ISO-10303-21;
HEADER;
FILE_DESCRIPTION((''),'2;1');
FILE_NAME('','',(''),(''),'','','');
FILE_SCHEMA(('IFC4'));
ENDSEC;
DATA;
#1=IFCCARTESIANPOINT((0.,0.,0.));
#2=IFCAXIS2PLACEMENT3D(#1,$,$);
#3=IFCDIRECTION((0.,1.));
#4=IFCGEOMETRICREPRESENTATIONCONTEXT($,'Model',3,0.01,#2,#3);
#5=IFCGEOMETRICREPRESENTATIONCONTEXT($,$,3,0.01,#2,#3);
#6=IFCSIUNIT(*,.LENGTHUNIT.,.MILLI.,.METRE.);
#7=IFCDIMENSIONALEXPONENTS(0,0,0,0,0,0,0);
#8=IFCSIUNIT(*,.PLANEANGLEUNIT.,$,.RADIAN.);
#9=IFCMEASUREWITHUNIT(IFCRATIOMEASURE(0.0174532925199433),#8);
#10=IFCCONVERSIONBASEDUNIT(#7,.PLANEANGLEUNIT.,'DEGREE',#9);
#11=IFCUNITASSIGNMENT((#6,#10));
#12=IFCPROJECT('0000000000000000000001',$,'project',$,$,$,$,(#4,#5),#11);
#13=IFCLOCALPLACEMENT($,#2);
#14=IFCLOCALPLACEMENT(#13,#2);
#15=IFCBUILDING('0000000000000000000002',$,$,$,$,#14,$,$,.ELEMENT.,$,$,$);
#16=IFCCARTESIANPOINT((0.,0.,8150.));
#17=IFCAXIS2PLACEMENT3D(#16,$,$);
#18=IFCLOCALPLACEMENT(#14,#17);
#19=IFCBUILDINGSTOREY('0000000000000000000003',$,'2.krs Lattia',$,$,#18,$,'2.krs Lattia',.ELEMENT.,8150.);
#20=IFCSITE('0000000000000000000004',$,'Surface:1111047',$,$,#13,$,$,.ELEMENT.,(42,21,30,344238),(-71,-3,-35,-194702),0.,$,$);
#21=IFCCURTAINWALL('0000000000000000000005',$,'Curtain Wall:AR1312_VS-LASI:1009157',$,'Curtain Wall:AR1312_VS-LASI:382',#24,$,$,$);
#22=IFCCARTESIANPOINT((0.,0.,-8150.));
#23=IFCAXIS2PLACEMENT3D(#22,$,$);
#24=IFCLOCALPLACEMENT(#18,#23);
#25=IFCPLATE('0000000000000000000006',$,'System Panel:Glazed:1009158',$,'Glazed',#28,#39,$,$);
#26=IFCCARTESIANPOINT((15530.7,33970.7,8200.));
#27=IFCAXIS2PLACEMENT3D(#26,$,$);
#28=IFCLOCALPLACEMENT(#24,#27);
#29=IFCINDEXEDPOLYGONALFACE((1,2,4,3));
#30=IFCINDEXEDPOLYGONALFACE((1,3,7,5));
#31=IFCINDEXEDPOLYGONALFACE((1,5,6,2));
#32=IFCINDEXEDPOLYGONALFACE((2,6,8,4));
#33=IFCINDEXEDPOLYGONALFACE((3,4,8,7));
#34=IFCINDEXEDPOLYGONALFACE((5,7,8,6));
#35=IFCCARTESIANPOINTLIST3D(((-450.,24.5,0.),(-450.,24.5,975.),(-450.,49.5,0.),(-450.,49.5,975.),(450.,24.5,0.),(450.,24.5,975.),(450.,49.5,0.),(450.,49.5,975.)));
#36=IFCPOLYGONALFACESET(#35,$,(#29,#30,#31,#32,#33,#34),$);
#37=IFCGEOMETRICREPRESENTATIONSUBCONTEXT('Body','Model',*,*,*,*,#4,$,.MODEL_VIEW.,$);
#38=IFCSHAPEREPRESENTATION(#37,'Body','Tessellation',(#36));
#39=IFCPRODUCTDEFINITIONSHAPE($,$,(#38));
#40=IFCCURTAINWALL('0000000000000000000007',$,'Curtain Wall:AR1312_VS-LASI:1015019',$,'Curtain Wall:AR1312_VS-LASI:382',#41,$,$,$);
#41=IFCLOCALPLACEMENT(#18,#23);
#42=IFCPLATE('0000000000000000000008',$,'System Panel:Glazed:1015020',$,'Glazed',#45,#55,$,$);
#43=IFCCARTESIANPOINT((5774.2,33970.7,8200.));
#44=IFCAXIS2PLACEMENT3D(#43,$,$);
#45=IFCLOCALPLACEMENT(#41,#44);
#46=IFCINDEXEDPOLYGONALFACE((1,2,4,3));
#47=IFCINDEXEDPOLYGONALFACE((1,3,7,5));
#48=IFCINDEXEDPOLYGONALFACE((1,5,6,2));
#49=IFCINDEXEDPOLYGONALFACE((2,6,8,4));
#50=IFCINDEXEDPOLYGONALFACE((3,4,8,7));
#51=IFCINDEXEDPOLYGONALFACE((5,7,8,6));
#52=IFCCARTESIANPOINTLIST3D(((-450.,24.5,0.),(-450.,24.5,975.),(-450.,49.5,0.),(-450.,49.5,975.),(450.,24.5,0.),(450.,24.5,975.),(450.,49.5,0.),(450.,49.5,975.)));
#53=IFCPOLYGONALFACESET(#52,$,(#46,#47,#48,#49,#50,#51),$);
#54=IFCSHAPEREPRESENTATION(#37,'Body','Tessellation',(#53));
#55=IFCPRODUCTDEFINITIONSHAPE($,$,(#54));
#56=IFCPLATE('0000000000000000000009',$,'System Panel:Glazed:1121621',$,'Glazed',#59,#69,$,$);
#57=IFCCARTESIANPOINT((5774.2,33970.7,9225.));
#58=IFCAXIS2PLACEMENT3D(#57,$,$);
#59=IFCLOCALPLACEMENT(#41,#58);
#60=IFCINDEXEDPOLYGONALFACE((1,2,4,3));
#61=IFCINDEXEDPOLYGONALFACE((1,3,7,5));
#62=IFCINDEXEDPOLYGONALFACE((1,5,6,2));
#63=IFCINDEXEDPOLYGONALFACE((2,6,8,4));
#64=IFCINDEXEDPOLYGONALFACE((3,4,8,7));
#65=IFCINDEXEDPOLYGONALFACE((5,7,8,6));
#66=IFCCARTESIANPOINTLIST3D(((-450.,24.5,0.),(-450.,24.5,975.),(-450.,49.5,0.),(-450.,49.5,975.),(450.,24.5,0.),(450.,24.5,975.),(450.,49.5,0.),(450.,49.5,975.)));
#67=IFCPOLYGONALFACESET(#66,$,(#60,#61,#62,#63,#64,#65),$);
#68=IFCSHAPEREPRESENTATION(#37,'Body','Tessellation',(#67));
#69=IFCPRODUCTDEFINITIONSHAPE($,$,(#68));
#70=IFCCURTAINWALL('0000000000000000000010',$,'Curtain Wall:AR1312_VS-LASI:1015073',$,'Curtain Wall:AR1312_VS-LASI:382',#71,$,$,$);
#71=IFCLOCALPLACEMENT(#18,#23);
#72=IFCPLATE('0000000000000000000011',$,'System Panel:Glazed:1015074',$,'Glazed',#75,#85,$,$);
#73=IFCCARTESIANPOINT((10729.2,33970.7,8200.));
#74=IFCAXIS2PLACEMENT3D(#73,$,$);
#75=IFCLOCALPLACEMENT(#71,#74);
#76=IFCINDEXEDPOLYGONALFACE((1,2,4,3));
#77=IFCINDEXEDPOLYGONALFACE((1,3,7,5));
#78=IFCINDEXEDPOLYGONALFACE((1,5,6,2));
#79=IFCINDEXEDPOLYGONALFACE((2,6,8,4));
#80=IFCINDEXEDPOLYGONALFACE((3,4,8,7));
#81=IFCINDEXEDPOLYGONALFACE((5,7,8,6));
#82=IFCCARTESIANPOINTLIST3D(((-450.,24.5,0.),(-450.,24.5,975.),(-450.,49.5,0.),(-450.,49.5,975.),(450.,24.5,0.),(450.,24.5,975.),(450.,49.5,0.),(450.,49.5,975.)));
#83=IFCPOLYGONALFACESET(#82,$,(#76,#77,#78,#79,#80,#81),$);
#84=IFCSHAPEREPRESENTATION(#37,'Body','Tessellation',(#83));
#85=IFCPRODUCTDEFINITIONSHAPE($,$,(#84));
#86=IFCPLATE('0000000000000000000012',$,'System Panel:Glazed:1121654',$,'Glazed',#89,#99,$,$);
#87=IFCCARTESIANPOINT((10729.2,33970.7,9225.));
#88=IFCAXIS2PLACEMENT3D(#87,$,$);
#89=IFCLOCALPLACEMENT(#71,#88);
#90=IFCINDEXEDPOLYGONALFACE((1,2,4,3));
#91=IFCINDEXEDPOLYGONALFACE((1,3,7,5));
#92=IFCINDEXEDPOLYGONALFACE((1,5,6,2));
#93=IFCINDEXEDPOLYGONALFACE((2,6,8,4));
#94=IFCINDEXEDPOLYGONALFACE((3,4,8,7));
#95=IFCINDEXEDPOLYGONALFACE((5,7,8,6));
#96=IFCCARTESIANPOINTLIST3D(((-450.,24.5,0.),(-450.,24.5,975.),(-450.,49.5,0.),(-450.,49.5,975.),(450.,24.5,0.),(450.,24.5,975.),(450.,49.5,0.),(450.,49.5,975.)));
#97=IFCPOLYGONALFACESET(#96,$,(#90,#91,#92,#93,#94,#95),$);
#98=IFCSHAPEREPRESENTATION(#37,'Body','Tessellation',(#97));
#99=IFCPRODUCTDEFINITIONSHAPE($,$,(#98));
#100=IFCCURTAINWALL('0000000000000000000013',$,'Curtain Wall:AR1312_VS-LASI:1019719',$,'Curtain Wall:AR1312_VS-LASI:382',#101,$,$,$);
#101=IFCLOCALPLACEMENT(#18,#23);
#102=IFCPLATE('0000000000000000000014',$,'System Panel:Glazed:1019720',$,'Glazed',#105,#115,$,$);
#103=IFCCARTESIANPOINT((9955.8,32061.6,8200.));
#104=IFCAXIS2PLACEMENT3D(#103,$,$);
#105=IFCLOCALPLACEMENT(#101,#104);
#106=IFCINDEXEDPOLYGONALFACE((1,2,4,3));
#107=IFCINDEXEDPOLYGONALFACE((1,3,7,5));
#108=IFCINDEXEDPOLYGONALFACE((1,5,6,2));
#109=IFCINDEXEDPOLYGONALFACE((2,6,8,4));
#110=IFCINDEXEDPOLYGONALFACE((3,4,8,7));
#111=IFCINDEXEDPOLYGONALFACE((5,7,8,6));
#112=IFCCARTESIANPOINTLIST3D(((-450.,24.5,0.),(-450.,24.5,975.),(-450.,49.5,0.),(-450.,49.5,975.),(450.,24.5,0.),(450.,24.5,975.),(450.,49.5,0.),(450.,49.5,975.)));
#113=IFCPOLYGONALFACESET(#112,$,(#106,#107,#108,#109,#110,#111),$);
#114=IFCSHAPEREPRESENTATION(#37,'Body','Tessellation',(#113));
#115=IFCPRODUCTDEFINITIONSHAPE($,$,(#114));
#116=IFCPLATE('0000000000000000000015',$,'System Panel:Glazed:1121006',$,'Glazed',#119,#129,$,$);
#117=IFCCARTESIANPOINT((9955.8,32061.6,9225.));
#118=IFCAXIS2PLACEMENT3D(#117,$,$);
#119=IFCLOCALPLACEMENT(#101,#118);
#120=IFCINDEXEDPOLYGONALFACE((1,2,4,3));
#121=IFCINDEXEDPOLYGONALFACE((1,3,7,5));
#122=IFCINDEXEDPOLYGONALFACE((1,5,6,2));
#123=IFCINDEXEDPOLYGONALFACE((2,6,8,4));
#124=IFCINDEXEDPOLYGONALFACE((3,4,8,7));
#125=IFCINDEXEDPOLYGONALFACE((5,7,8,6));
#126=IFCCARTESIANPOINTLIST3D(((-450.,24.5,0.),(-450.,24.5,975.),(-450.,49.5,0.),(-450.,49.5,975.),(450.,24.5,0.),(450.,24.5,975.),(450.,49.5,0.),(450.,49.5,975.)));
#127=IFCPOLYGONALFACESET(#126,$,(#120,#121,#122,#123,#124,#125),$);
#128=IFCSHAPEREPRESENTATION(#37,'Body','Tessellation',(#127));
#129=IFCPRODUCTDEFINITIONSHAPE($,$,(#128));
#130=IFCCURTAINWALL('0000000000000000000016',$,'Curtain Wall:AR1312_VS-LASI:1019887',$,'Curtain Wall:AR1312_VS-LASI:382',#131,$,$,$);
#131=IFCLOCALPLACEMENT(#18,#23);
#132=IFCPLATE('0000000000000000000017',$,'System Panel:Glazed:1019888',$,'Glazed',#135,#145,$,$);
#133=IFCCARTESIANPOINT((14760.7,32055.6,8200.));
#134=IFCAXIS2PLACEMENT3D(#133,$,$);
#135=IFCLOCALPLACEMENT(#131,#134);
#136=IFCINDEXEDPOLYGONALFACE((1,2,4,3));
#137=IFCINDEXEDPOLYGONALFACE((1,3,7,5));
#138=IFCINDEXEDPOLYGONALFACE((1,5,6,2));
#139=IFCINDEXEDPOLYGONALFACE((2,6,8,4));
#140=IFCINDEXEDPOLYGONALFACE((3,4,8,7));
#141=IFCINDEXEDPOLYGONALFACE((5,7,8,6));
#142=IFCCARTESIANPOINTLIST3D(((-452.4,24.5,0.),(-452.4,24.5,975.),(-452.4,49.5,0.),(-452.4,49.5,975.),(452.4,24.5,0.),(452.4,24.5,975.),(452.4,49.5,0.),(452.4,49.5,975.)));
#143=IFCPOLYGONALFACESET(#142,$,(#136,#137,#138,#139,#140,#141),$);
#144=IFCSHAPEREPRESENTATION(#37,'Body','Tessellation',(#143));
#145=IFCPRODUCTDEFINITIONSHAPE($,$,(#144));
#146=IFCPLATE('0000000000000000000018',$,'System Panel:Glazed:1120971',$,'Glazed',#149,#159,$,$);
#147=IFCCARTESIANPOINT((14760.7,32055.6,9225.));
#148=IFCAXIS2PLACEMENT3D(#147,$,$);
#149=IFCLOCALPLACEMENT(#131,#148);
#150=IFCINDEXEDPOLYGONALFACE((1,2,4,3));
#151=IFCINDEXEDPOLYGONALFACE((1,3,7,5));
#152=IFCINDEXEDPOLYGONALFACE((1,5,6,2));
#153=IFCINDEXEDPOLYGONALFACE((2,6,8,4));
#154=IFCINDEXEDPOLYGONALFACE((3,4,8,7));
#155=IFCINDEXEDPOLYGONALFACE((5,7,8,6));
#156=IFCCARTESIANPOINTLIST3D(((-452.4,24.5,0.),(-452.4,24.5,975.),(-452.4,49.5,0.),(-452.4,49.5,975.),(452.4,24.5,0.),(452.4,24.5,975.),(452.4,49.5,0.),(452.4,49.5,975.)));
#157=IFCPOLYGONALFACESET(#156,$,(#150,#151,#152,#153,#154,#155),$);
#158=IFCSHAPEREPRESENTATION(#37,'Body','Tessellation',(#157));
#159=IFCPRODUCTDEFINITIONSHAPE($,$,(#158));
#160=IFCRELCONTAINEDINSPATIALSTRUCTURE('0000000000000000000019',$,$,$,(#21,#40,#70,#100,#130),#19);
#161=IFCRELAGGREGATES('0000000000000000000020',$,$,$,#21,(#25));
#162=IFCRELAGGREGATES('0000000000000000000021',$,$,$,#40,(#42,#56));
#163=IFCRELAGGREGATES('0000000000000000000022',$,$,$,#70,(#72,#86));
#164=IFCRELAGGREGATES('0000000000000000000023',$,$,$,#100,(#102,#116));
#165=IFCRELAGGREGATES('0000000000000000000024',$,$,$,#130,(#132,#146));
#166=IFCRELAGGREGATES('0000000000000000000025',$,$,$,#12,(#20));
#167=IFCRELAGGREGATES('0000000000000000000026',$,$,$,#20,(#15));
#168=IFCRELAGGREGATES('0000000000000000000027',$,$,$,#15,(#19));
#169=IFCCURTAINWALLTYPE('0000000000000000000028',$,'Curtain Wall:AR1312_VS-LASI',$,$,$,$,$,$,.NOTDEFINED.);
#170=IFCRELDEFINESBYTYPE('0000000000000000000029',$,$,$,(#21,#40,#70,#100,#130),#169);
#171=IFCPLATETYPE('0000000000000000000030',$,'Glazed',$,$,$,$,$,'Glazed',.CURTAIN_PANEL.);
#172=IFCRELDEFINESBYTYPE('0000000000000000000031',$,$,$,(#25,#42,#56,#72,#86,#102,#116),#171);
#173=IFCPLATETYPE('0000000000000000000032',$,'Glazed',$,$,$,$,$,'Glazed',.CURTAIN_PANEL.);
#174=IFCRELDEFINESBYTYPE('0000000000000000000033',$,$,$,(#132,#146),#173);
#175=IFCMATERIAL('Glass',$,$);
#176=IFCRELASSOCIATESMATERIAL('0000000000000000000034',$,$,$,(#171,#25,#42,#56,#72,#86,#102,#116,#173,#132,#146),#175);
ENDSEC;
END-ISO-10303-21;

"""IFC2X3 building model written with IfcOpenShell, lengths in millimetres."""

from ifc_helpers import new_model, entity, si_unit, converted_unit, direction, frame, origin, origin_2d_with_axis, place, context, subcontext, project, spatial, rectangle, extrude, source, transform, mapped, material, type_object, type_shapes, element, aggregate, save


model = new_model("IFC2X3")

# Units and contexts
model_context = context("Model", 3, precision=0.01, world=origin(), true_north=direction((0.0, 1.0)))
context_of_model = context(None, 3, precision=0.01, world=origin(), true_north=direction((0.0, 1.0)))
body_context = subcontext(model_context, "Body", "Model", "MODEL_VIEW")
ifc_project = project(units=[si_unit("LENGTHUNIT", "METRE", prefix="MILLI"), converted_unit("PLANEANGLEUNIT", "DEGREE", entity("IfcRatioMeasure", 0.0174532925199433), si_unit("PLANEANGLEUNIT", "RADIAN"), dimensions=[0, 0, 0, 0, 0, 0, 0])], contexts=[model_context, context_of_model])

# Site, building, storey
site_placement = place(None, origin())
site = spatial("IfcSite", under=ifc_project, at=site_placement, Name="Surface:1111047", CompositionType="ELEMENT", RefLatitude=(42, 21, 30, 344238), RefLongitude=(-71, -3, -35, -194702), RefElevation=0.0)
building_placement = place(site_placement, origin())
building = spatial("IfcBuilding", under=site, at=building_placement, CompositionType="ELEMENT")
storey_placement = place(building_placement, frame((0.0, 0.0, 8150.0)))
storey = spatial("IfcBuildingStorey", under=building, at=storey_placement, Name="2.krs Lattia", LongName="2.krs Lattia", CompositionType="ELEMENT", Elevation=8150.0)

# Curtain wall, plate
curtain_wall_type = type_object("IfcCurtainWallType", Name="Curtain Wall:AR1312_VS-LASI", PredefinedType="NOTDEFINED")
curtain_wall_1_placement = place(storey_placement, frame((0.0, 0.0, -8150.0)))
curtain_wall_1 = element("IfcCurtainWall", 1, at=curtain_wall_1_placement, inside=storey, type_object=curtain_wall_type, Name="Curtain Wall:AR1312_VS-LASI:1009157", ObjectType="Curtain Wall:AR1312_VS-LASI:382")
ifc_material_1 = material(Name="Glass")
plate_type_1 = type_object("IfcPlateType", Name="Glazed", ElementType="Glazed", PredefinedType="CURTAIN_PANEL", material=ifc_material_1)
shared_shape_1 = source(origin(), body_context, "Body", "SweptSolid", [
    extrude(rectangle(XDim=25.0, YDim=900.0, at=origin_2d_with_axis()), frame((0.0, 37.0, 0.0), z_axis=(0.0, 0.0, 1.0), x_axis=(0.0, 1.0, 0.0)), (0.0, 0.0, 1.0), 975.0),
])
type_shapes(plate_type_1, [shared_shape_1])
plate_1_placement = place(curtain_wall_1_placement, frame((15530.7, 33970.7, 8200.0)))
plate_1 = element("IfcPlate", 2, at=plate_1_placement, type_object=plate_type_1, material=ifc_material_1, Name="System Panel:Glazed:1009158", ObjectType="Glazed", context=body_context, shape_type="MappedRepresentation", body=[
    mapped(shared_shape_1, transform((0.0, 0.0, 0.0), scale=1.0)),
])
aggregate(curtain_wall_1, [plate_1])

# Curtain walls, plates
curtain_wall_2_placement = place(storey_placement, frame((0.0, 0.0, -8150.0)))
curtain_wall_2 = element("IfcCurtainWall", 3, at=curtain_wall_2_placement, inside=storey, type_object=curtain_wall_type, Name="Curtain Wall:AR1312_VS-LASI:1015019", ObjectType="Curtain Wall:AR1312_VS-LASI:382")
plate_2_placement = place(curtain_wall_2_placement, frame((5774.2, 33970.7, 8200.0)))
plate_2 = element("IfcPlate", 4, at=plate_2_placement, type_object=plate_type_1, material=ifc_material_1, Name="System Panel:Glazed:1015020", ObjectType="Glazed", context=body_context, shape_type="MappedRepresentation", body=[
    mapped(shared_shape_1, transform((0.0, 0.0, 0.0), scale=1.0)),
])
plate_3_placement = place(curtain_wall_2_placement, frame((5774.2, 33970.7, 9225.0)))
plate_3 = element("IfcPlate", 5, at=plate_3_placement, type_object=plate_type_1, material=ifc_material_1, Name="System Panel:Glazed:1121621", ObjectType="Glazed", context=body_context, shape_type="MappedRepresentation", body=[
    mapped(shared_shape_1, transform((0.0, 0.0, 0.0), scale=1.0)),
])
aggregate(curtain_wall_2, [plate_2, plate_3])
curtain_wall_3_placement = place(storey_placement, frame((0.0, 0.0, -8150.0)))
curtain_wall_3 = element("IfcCurtainWall", 6, at=curtain_wall_3_placement, inside=storey, type_object=curtain_wall_type, Name="Curtain Wall:AR1312_VS-LASI:1015073", ObjectType="Curtain Wall:AR1312_VS-LASI:382")
plate_4_placement = place(curtain_wall_3_placement, frame((10729.2, 33970.7, 8200.0)))
plate_4 = element("IfcPlate", 7, at=plate_4_placement, type_object=plate_type_1, material=ifc_material_1, Name="System Panel:Glazed:1015074", ObjectType="Glazed", context=body_context, shape_type="MappedRepresentation", body=[
    mapped(shared_shape_1, transform((0.0, 0.0, 0.0), scale=1.0)),
])
plate_5_placement = place(curtain_wall_3_placement, frame((10729.2, 33970.7, 9225.0)))
plate_5 = element("IfcPlate", 8, at=plate_5_placement, type_object=plate_type_1, material=ifc_material_1, Name="System Panel:Glazed:1121654", ObjectType="Glazed", context=body_context, shape_type="MappedRepresentation", body=[
    mapped(shared_shape_1, transform((0.0, 0.0, 0.0), scale=1.0)),
])
aggregate(curtain_wall_3, [plate_4, plate_5])
curtain_wall_4_placement = place(storey_placement, frame((0.0, 0.0, -8150.0)))
curtain_wall_4 = element("IfcCurtainWall", 9, at=curtain_wall_4_placement, inside=storey, type_object=curtain_wall_type, Name="Curtain Wall:AR1312_VS-LASI:1019719", ObjectType="Curtain Wall:AR1312_VS-LASI:382")
plate_6_placement = place(curtain_wall_4_placement, frame((9955.8, 32061.6, 8200.0)))
plate_6 = element("IfcPlate", 10, at=plate_6_placement, type_object=plate_type_1, material=ifc_material_1, Name="System Panel:Glazed:1019720", ObjectType="Glazed", context=body_context, shape_type="MappedRepresentation", body=[
    mapped(shared_shape_1, transform((0.0, 0.0, 0.0), scale=1.0)),
])
plate_7_placement = place(curtain_wall_4_placement, frame((9955.8, 32061.6, 9225.0)))
plate_7 = element("IfcPlate", 11, at=plate_7_placement, type_object=plate_type_1, material=ifc_material_1, Name="System Panel:Glazed:1121006", ObjectType="Glazed", context=body_context, shape_type="MappedRepresentation", body=[
    mapped(shared_shape_1, transform((0.0, 0.0, 0.0), scale=1.0)),
])
aggregate(curtain_wall_4, [plate_6, plate_7])
curtain_wall_5_placement = place(storey_placement, frame((0.0, 0.0, -8150.0)))
curtain_wall_5 = element("IfcCurtainWall", 12, at=curtain_wall_5_placement, inside=storey, type_object=curtain_wall_type, Name="Curtain Wall:AR1312_VS-LASI:1019887", ObjectType="Curtain Wall:AR1312_VS-LASI:382")
plate_type_2 = type_object("IfcPlateType", Name="Glazed", ElementType="Glazed", PredefinedType="CURTAIN_PANEL", material=ifc_material_1)
shared_shape_2 = source(origin(), body_context, "Body", "SweptSolid", [
    extrude(rectangle(XDim=25.0, YDim=904.8, at=origin_2d_with_axis()), frame((0.0, 37.0, 0.0), z_axis=(0.0, 0.0, 1.0), x_axis=(0.0, 1.0, 0.0)), (0.0, 0.0, 1.0), 975.0),
])
type_shapes(plate_type_2, [shared_shape_2])
plate_8_placement = place(curtain_wall_5_placement, frame((14760.7, 32055.6, 8200.0)))
plate_8 = element("IfcPlate", 13, at=plate_8_placement, type_object=plate_type_2, material=ifc_material_1, Name="System Panel:Glazed:1019888", ObjectType="Glazed", context=body_context, shape_type="MappedRepresentation", body=[
    mapped(shared_shape_2, transform((0.0, 0.0, 0.0), scale=1.0)),
])
plate_9_placement = place(curtain_wall_5_placement, frame((14760.7, 32055.6, 9225.0)))
plate_9 = element("IfcPlate", 14, at=plate_9_placement, type_object=plate_type_2, material=ifc_material_1, Name="System Panel:Glazed:1120971", ObjectType="Glazed", context=body_context, shape_type="MappedRepresentation", body=[
    mapped(shared_shape_2, transform((0.0, 0.0, 0.0), scale=1.0)),
])
aggregate(curtain_wall_5, [plate_8, plate_9])

save(model, "model.ifc")
